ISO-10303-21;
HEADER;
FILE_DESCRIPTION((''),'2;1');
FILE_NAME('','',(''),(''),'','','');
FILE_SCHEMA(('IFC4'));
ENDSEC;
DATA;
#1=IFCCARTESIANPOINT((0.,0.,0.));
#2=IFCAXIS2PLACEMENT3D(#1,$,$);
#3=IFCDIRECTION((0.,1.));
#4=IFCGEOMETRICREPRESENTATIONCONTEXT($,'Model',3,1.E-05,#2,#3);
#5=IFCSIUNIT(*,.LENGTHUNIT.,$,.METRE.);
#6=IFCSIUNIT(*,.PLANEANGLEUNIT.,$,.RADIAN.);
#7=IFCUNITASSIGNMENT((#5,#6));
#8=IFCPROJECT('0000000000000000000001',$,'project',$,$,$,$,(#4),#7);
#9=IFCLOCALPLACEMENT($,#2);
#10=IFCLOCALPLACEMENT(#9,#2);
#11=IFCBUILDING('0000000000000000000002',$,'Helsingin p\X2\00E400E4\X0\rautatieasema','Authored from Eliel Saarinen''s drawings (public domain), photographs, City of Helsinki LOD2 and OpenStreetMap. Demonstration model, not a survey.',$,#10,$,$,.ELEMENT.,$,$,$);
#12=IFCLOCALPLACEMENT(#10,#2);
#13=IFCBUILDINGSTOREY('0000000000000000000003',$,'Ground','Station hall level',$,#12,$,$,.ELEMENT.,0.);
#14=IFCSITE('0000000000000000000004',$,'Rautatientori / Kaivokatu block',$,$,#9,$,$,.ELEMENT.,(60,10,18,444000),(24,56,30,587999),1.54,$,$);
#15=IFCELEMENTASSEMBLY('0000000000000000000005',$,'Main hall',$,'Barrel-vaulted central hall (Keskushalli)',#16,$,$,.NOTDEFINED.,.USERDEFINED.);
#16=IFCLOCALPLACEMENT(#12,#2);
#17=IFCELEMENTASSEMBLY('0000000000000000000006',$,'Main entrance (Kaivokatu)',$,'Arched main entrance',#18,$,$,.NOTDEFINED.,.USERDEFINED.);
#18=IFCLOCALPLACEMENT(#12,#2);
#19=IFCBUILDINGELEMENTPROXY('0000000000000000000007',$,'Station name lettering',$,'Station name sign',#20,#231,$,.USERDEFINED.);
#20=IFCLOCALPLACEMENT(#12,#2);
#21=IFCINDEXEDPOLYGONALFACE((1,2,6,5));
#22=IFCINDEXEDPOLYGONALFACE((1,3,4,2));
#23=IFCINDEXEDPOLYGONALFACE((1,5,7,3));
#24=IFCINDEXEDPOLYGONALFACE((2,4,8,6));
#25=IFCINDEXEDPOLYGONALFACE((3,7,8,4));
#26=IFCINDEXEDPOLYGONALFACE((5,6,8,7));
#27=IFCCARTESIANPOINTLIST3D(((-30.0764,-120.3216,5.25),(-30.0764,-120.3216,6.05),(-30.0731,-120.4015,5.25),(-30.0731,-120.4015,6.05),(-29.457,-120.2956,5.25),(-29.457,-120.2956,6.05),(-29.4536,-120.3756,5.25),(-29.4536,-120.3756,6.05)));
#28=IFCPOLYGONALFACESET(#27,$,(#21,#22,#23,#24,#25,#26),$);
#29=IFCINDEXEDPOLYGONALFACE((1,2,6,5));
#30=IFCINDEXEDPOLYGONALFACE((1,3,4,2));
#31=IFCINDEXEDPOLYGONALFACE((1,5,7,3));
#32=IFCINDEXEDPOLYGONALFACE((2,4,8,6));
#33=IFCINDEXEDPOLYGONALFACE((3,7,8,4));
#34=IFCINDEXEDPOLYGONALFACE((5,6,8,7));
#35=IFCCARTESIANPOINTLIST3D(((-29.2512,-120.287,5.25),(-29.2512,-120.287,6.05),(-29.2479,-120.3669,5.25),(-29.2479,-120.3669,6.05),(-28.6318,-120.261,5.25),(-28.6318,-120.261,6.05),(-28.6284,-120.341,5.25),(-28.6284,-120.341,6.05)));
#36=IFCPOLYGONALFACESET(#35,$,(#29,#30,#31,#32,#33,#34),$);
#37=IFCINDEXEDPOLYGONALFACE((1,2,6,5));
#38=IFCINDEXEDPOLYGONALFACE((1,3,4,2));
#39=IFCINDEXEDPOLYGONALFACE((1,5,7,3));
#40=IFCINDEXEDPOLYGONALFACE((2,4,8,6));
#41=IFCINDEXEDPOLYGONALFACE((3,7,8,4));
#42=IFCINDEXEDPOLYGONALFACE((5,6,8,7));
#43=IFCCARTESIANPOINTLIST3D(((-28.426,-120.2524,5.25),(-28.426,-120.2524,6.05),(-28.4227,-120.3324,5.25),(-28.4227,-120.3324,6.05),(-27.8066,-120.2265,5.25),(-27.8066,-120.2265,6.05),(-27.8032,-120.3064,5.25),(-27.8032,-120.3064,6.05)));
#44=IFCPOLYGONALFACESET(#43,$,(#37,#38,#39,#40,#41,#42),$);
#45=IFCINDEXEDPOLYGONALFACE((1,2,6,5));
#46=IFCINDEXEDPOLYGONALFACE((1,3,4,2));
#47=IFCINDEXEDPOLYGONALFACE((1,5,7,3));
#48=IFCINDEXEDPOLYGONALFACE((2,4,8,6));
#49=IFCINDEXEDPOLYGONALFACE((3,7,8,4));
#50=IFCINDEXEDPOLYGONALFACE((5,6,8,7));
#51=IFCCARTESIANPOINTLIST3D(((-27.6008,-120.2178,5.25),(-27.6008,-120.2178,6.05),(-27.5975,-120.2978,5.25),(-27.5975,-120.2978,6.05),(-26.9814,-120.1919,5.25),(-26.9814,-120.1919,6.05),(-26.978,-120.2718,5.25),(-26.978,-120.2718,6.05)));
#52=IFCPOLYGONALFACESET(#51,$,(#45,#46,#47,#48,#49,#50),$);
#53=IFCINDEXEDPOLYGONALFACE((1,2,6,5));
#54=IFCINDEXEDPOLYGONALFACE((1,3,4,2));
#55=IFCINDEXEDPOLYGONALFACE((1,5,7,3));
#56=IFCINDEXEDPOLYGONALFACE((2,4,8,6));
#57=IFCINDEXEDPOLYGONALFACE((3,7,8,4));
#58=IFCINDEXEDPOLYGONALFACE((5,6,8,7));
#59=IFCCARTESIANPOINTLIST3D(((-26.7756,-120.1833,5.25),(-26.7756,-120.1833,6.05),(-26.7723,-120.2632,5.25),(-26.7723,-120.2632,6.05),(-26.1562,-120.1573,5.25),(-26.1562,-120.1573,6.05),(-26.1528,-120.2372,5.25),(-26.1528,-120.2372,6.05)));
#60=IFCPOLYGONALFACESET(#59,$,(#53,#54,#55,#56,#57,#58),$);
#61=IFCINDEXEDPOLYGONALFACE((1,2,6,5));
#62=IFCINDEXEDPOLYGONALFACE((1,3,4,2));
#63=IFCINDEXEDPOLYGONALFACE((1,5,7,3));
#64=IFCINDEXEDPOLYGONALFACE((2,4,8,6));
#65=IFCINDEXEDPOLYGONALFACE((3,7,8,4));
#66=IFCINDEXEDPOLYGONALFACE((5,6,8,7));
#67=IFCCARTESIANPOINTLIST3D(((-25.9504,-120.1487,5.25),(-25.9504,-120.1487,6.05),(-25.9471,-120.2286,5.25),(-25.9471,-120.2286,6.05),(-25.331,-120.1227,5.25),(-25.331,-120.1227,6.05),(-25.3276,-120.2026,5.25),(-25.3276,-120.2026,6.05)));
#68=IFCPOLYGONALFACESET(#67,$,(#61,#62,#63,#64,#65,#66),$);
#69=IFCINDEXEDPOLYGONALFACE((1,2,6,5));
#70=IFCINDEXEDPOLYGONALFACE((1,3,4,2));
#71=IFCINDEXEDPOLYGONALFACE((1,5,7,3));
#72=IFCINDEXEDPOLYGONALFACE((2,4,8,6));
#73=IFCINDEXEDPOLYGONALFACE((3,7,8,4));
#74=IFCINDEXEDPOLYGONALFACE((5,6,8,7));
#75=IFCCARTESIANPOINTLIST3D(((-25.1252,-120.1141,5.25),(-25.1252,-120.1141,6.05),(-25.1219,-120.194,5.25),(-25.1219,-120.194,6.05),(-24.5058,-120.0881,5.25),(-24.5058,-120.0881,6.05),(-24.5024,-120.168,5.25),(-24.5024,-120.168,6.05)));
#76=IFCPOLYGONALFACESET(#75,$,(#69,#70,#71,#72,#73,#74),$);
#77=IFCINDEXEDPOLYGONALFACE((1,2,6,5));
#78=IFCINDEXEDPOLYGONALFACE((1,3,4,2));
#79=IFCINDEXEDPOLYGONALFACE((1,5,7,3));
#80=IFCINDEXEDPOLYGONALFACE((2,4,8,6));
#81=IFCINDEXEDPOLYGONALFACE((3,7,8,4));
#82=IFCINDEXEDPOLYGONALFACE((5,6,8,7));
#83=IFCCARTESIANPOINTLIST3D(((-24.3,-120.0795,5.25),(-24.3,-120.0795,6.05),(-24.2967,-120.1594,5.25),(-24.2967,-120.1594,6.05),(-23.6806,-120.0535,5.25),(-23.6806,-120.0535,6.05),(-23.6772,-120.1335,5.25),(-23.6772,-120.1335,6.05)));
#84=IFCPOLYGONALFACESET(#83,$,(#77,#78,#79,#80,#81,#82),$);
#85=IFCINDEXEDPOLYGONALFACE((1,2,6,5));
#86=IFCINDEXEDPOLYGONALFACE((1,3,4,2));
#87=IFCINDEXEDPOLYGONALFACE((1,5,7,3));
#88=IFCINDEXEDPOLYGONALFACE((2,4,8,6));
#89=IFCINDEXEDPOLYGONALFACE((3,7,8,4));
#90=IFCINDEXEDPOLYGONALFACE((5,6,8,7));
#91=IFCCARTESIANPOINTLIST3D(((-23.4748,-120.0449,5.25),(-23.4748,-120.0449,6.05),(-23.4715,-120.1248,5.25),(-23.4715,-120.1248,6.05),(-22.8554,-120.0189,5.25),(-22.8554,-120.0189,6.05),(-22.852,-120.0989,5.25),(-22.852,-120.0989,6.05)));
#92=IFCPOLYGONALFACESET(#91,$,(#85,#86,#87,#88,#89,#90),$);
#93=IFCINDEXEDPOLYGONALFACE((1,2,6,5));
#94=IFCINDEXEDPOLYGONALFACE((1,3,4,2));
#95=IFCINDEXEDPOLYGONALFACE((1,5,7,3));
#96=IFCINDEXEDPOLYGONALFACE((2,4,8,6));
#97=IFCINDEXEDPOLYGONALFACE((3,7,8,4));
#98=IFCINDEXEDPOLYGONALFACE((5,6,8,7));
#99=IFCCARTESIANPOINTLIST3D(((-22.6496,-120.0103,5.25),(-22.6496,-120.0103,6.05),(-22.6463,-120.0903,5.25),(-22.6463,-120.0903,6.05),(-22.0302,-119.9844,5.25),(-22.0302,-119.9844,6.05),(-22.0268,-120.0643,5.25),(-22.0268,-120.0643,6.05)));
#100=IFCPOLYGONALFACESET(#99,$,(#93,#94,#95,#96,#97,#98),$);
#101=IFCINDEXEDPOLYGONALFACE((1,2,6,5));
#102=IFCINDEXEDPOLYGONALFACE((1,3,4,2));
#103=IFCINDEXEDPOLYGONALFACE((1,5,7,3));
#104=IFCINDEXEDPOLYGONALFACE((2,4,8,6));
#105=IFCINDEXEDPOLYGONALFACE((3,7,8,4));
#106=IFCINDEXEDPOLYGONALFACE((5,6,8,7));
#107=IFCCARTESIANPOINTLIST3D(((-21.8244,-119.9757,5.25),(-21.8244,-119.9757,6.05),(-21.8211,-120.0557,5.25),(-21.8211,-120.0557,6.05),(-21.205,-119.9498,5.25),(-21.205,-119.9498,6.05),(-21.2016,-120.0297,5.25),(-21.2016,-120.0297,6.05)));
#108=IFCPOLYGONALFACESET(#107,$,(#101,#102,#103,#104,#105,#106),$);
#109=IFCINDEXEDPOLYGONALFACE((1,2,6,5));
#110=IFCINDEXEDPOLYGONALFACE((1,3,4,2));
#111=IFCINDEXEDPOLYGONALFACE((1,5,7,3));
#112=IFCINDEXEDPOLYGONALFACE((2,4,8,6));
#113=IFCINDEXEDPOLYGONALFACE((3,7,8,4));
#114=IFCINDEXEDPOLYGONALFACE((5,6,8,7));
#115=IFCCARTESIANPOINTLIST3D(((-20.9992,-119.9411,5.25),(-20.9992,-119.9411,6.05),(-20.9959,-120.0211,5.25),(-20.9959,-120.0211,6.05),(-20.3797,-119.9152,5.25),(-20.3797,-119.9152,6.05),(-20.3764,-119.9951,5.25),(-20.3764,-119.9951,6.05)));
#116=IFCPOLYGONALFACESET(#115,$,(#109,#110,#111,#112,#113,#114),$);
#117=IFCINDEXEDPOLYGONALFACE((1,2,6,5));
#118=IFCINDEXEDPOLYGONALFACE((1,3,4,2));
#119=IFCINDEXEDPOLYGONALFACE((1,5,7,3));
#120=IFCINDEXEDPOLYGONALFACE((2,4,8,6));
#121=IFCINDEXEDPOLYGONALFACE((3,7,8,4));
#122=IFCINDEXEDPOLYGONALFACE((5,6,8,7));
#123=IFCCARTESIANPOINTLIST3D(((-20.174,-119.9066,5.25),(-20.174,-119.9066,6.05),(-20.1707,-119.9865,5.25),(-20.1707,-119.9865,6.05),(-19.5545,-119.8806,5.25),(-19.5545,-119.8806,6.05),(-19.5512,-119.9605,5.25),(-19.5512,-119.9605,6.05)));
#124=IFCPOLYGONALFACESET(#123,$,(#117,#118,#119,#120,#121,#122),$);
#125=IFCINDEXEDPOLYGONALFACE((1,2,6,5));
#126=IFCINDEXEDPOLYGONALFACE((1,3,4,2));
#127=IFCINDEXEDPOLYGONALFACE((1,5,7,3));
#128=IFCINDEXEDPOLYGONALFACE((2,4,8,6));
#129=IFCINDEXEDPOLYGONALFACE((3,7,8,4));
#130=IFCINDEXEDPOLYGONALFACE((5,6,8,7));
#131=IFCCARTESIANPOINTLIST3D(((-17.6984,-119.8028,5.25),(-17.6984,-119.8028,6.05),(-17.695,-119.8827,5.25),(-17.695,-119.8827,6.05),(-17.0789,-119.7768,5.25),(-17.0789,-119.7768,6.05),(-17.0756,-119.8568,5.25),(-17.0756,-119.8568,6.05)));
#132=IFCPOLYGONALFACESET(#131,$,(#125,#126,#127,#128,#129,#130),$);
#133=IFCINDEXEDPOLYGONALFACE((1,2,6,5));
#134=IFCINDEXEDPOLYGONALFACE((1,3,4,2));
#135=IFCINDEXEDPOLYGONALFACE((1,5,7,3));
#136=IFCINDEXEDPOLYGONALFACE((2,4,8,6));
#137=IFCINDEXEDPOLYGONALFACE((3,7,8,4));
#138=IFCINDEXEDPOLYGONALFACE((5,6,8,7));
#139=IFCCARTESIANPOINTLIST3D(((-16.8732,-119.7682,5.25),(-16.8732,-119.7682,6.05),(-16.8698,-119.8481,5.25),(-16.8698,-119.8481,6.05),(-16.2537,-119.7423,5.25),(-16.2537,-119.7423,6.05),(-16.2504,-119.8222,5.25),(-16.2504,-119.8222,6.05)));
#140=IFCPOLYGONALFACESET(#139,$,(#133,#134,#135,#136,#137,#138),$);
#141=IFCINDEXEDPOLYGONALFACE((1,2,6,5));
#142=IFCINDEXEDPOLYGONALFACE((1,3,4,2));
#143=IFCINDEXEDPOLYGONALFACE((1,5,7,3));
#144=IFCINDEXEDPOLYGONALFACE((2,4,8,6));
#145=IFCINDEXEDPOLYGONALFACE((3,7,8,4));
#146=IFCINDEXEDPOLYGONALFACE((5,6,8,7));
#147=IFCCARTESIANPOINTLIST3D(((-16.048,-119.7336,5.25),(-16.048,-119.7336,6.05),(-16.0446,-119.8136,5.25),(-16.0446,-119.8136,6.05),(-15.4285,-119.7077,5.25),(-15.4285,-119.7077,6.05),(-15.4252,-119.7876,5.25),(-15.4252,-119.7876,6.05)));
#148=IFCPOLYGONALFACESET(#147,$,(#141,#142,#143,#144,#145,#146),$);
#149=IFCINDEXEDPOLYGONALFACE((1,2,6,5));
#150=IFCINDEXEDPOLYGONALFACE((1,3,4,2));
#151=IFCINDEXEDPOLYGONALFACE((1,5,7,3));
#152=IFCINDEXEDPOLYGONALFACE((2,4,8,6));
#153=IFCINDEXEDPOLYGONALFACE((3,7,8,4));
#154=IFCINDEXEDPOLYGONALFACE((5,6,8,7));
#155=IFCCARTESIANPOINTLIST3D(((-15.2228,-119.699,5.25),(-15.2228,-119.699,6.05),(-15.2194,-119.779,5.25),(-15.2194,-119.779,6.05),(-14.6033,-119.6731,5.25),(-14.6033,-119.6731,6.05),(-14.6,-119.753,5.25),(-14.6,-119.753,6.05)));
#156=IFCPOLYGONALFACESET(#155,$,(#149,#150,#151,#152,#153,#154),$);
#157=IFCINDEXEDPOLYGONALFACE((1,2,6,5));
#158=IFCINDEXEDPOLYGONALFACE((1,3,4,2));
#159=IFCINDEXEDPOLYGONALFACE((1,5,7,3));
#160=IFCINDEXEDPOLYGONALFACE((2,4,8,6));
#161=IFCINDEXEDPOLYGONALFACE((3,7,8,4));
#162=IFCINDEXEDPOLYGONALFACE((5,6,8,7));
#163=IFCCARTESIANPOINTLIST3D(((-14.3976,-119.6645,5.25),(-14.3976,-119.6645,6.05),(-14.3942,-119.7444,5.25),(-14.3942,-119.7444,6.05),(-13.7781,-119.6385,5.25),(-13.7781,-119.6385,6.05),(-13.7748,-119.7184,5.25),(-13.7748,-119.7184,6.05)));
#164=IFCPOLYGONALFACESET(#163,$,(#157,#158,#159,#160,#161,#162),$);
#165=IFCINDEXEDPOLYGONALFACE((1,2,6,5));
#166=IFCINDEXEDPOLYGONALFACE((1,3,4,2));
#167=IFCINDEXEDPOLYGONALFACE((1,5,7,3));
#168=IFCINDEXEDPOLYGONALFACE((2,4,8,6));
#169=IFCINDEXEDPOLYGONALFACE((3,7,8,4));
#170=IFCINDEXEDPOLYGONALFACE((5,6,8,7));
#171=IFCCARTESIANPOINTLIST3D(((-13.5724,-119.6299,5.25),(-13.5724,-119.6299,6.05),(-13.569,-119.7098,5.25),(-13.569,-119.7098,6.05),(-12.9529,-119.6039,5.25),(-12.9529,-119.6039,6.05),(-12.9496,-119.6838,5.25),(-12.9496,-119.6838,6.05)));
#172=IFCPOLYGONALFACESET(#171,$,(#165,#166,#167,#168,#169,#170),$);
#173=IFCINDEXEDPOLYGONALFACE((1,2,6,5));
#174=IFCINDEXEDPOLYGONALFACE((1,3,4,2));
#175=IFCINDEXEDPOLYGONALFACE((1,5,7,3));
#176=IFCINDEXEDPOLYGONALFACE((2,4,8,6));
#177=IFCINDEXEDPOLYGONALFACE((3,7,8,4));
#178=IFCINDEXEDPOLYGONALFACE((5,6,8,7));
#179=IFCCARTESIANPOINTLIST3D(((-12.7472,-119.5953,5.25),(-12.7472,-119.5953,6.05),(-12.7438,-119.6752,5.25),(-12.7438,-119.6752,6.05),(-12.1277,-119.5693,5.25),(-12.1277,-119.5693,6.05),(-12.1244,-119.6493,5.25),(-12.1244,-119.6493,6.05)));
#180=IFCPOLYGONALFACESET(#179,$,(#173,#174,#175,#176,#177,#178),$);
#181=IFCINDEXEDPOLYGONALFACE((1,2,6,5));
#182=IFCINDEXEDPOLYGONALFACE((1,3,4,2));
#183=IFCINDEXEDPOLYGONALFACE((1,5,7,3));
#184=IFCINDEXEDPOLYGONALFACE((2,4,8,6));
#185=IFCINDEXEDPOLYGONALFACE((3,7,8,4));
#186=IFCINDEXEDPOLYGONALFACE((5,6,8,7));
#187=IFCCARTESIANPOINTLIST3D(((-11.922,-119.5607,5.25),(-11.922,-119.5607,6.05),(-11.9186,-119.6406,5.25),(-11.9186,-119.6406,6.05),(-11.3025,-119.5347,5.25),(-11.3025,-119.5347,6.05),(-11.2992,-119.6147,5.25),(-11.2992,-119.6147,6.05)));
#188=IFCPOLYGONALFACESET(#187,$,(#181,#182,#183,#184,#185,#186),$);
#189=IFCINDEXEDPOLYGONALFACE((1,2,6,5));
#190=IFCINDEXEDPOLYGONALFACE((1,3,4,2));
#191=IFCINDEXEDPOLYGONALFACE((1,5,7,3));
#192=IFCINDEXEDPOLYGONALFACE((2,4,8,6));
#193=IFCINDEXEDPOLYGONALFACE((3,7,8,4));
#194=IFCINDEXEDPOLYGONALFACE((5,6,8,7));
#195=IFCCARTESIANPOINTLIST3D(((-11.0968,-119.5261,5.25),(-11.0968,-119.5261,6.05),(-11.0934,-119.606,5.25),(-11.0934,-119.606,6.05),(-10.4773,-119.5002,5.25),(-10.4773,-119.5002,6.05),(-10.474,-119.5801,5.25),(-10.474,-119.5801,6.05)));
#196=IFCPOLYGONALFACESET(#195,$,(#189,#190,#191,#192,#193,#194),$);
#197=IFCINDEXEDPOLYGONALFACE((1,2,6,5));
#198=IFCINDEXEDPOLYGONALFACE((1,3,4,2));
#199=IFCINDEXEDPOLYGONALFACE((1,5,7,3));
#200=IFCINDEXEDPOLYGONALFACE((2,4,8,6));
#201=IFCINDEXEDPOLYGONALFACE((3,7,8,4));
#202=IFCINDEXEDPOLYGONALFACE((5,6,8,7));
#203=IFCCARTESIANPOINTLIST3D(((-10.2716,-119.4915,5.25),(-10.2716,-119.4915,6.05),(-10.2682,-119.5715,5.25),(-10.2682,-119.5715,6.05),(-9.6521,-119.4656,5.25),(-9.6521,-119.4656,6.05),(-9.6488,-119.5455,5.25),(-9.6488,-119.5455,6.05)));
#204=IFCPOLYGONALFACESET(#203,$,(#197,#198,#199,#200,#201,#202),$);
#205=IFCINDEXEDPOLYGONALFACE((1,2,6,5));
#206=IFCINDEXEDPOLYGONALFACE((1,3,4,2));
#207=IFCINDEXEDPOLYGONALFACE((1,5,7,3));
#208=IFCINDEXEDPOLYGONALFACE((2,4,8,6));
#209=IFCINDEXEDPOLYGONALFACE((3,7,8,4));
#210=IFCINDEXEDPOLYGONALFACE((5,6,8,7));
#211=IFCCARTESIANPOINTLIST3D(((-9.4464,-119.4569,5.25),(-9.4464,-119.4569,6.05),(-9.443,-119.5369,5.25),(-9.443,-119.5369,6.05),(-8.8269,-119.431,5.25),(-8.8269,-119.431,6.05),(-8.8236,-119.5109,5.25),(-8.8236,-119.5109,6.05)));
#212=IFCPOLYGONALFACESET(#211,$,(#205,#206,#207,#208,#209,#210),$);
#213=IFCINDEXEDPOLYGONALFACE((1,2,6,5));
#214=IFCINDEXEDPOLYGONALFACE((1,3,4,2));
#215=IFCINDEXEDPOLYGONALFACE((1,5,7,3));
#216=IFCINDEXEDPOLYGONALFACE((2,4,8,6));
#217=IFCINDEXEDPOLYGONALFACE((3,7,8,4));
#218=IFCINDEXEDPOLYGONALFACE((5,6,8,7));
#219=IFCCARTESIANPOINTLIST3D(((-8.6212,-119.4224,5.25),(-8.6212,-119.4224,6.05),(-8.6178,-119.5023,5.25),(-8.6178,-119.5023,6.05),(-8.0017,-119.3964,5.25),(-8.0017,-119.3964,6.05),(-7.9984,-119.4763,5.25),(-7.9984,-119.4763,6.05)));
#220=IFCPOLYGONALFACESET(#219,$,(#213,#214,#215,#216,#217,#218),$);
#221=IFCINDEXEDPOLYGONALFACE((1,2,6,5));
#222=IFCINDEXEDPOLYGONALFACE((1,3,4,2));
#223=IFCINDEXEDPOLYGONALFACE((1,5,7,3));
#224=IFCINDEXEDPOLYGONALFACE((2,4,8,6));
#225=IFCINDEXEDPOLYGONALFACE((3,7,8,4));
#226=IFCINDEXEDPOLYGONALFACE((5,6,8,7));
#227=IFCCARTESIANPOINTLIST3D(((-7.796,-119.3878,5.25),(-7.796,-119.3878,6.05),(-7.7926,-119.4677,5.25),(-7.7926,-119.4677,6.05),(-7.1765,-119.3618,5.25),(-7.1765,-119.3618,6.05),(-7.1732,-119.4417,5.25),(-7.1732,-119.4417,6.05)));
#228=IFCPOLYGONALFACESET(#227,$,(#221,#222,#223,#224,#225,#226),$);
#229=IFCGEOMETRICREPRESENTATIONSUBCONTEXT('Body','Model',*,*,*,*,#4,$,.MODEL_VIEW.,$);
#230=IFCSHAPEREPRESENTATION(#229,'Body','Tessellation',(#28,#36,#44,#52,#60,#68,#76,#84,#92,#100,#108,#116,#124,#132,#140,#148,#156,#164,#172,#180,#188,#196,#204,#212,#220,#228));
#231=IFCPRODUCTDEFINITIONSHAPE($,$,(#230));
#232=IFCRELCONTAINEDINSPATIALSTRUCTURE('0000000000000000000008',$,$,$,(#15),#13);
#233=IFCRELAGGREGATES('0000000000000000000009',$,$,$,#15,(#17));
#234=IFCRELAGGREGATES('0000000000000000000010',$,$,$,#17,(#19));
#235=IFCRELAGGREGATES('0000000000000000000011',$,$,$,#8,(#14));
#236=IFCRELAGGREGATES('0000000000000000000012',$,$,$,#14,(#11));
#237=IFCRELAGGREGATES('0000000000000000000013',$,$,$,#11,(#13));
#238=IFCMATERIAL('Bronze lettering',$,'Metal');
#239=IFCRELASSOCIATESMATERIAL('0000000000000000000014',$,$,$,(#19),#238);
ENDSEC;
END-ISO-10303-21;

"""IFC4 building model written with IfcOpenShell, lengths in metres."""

from ifc_helpers import new_model, si_unit, direction, frame, frame_2d, origin, place, context, subcontext, project, spatial, rectangle, extrude, material, element, aggregate, save


model = new_model("IFC4")

# Units and contexts
model_context = context("Model", 3, precision=1e-05, world=origin(), true_north=direction((0.0, 1.0)))
body_context = subcontext(model_context, "Body", "Model", "MODEL_VIEW")
ifc_project = project(units=[si_unit("LENGTHUNIT", "METRE"), si_unit("PLANEANGLEUNIT", "RADIAN")], contexts=[model_context])

# Site, building, storey
site_placement = place(None, origin())
site = spatial("IfcSite", under=ifc_project, at=site_placement, Name="Rautatientori / Kaivokatu block", CompositionType="ELEMENT", RefLatitude=(60, 10, 18, 444000), RefLongitude=(24, 56, 30, 587999), RefElevation=1.54)
building_placement = place(site_placement, origin())
building = spatial("IfcBuilding", under=site, at=building_placement, Name="Helsingin päärautatieasema", Description="Authored from Eliel Saarinen's drawings (public domain), photographs, City of Helsinki LOD2 and OpenStreetMap. Demonstration model, not a survey.", CompositionType="ELEMENT")
storey_placement = place(building_placement, origin())
storey = spatial("IfcBuildingStorey", under=building, at=storey_placement, Name="Ground", Description="Station hall level", CompositionType="ELEMENT", Elevation=0.0)

# Element assemblies, building element proxy
assembly_1_placement = place(building_placement, origin())
assembly_1 = element("IfcElementAssembly", 1, at=assembly_1_placement, inside=storey, Name="Main hall", ObjectType="Barrel-vaulted central hall (Keskushalli)", AssemblyPlace="NOTDEFINED", PredefinedType="USERDEFINED")
assembly_2_placement = place(building_placement, origin())
assembly_2 = element("IfcElementAssembly", 2, at=assembly_2_placement, Name="Main entrance (Kaivokatu)", ObjectType="Arched main entrance", AssemblyPlace="NOTDEFINED", PredefinedType="USERDEFINED")
aggregate(assembly_1, [assembly_2])
ifc_material_1 = material(Name="Bronze lettering", Category="Metal")
proxy_1_placement = place(building_placement, origin())
proxy_1 = element("IfcBuildingElementProxy", 3, at=proxy_1_placement, material=ifc_material_1, Name="Station name lettering", ObjectType="Station name sign", PredefinedType="USERDEFINED", context=body_context, shape_type="SweptSolid", body=[
    extrude(rectangle(XDim=0.62, YDim=0.08, at=frame_2d((0.0, 0.0), x_axis=(0.999123, 0.041876))), frame((-29.765, -120.3486, 5.25)), (0.0, 0.0, 1.0), 0.8),
    extrude(rectangle(XDim=0.62, YDim=0.08, at=frame_2d((0.0, 0.0), x_axis=(0.999123, 0.041876))), frame((-28.9398, -120.314, 5.25)), (0.0, 0.0, 1.0), 0.8),
    extrude(rectangle(XDim=0.62, YDim=0.08, at=frame_2d((0.0, 0.0), x_axis=(0.999123, 0.041876))), frame((-28.1146, -120.2794, 5.25)), (0.0, 0.0, 1.0), 0.8),
    extrude(rectangle(XDim=0.62, YDim=0.08, at=frame_2d((0.0, 0.0), x_axis=(0.999123, 0.041876))), frame((-27.2894, -120.2448, 5.25)), (0.0, 0.0, 1.0), 0.8),
    extrude(rectangle(XDim=0.62, YDim=0.08, at=frame_2d((0.0, 0.0), x_axis=(0.999123, 0.041876))), frame((-26.4642, -120.2102, 5.25)), (0.0, 0.0, 1.0), 0.8),
    extrude(rectangle(XDim=0.62, YDim=0.08, at=frame_2d((0.0, 0.0), x_axis=(0.999123, 0.041876))), frame((-25.639, -120.1756, 5.25)), (0.0, 0.0, 1.0), 0.8),
    extrude(rectangle(XDim=0.62, YDim=0.08, at=frame_2d((0.0, 0.0), x_axis=(0.999123, 0.041876))), frame((-24.8138, -120.1411, 5.25)), (0.0, 0.0, 1.0), 0.8),
    extrude(rectangle(XDim=0.62, YDim=0.08, at=frame_2d((0.0, 0.0), x_axis=(0.999123, 0.041876))), frame((-23.9886, -120.1065, 5.25)), (0.0, 0.0, 1.0), 0.8),
    extrude(rectangle(XDim=0.62, YDim=0.08, at=frame_2d((0.0, 0.0), x_axis=(0.999123, 0.041876))), frame((-23.1634, -120.0719, 5.25)), (0.0, 0.0, 1.0), 0.8),
    extrude(rectangle(XDim=0.62, YDim=0.08, at=frame_2d((0.0, 0.0), x_axis=(0.999123, 0.041876))), frame((-22.3382, -120.0373, 5.25)), (0.0, 0.0, 1.0), 0.8),
    extrude(rectangle(XDim=0.62, YDim=0.08, at=frame_2d((0.0, 0.0), x_axis=(0.999123, 0.041876))), frame((-21.513, -120.0027, 5.25)), (0.0, 0.0, 1.0), 0.8),
    extrude(rectangle(XDim=0.62, YDim=0.08, at=frame_2d((0.0, 0.0), x_axis=(0.999123, 0.041876))), frame((-20.6878, -119.9681, 5.25)), (0.0, 0.0, 1.0), 0.8),
    extrude(rectangle(XDim=0.62, YDim=0.08, at=frame_2d((0.0, 0.0), x_axis=(0.999123, 0.041876))), frame((-19.8626, -119.9335, 5.25)), (0.0, 0.0, 1.0), 0.8),
    extrude(rectangle(XDim=0.62, YDim=0.08, at=frame_2d((0.0, 0.0), x_axis=(0.999123, 0.041876))), frame((-17.387, -119.8298, 5.25)), (0.0, 0.0, 1.0), 0.8),
    extrude(rectangle(XDim=0.62, YDim=0.08, at=frame_2d((0.0, 0.0), x_axis=(0.999123, 0.041876))), frame((-16.5618, -119.7952, 5.25)), (0.0, 0.0, 1.0), 0.8),
    extrude(rectangle(XDim=0.62, YDim=0.08, at=frame_2d((0.0, 0.0), x_axis=(0.999123, 0.041876))), frame((-15.7366, -119.7606, 5.25)), (0.0, 0.0, 1.0), 0.8),
    extrude(rectangle(XDim=0.62, YDim=0.08, at=frame_2d((0.0, 0.0), x_axis=(0.999123, 0.041876))), frame((-14.9114, -119.726, 5.25)), (0.0, 0.0, 1.0), 0.8),
    extrude(rectangle(XDim=0.62, YDim=0.08, at=frame_2d((0.0, 0.0), x_axis=(0.999123, 0.041876))), frame((-14.0862, -119.6914, 5.25)), (0.0, 0.0, 1.0), 0.8),
    extrude(rectangle(XDim=0.62, YDim=0.08, at=frame_2d((0.0, 0.0), x_axis=(0.999123, 0.041876))), frame((-13.261, -119.6569, 5.25)), (0.0, 0.0, 1.0), 0.8),
    extrude(rectangle(XDim=0.62, YDim=0.08, at=frame_2d((0.0, 0.0), x_axis=(0.999123, 0.041876))), frame((-12.4358, -119.6223, 5.25)), (0.0, 0.0, 1.0), 0.8),
    extrude(rectangle(XDim=0.62, YDim=0.08, at=frame_2d((0.0, 0.0), x_axis=(0.999123, 0.041876))), frame((-11.6106, -119.5877, 5.25)), (0.0, 0.0, 1.0), 0.8),
    extrude(rectangle(XDim=0.62, YDim=0.08, at=frame_2d((0.0, 0.0), x_axis=(0.999123, 0.041876))), frame((-10.7854, -119.5531, 5.25)), (0.0, 0.0, 1.0), 0.8),
    extrude(rectangle(XDim=0.62, YDim=0.08, at=frame_2d((0.0, 0.0), x_axis=(0.999123, 0.041876))), frame((-9.9602, -119.5185, 5.25)), (0.0, 0.0, 1.0), 0.8),
    extrude(rectangle(XDim=0.62, YDim=0.08, at=frame_2d((0.0, 0.0), x_axis=(0.999123, 0.041876))), frame((-9.135, -119.4839, 5.25)), (0.0, 0.0, 1.0), 0.8),
    extrude(rectangle(XDim=0.62, YDim=0.08, at=frame_2d((0.0, 0.0), x_axis=(0.999123, 0.041876))), frame((-8.3098, -119.4493, 5.25)), (0.0, 0.0, 1.0), 0.8),
    extrude(rectangle(XDim=0.62, YDim=0.08, at=frame_2d((0.0, 0.0), x_axis=(0.999123, 0.041876))), frame((-7.4846, -119.4148, 5.25)), (0.0, 0.0, 1.0), 0.8),
])
aggregate(assembly_2, [proxy_1])

save(model, "model.ifc")
